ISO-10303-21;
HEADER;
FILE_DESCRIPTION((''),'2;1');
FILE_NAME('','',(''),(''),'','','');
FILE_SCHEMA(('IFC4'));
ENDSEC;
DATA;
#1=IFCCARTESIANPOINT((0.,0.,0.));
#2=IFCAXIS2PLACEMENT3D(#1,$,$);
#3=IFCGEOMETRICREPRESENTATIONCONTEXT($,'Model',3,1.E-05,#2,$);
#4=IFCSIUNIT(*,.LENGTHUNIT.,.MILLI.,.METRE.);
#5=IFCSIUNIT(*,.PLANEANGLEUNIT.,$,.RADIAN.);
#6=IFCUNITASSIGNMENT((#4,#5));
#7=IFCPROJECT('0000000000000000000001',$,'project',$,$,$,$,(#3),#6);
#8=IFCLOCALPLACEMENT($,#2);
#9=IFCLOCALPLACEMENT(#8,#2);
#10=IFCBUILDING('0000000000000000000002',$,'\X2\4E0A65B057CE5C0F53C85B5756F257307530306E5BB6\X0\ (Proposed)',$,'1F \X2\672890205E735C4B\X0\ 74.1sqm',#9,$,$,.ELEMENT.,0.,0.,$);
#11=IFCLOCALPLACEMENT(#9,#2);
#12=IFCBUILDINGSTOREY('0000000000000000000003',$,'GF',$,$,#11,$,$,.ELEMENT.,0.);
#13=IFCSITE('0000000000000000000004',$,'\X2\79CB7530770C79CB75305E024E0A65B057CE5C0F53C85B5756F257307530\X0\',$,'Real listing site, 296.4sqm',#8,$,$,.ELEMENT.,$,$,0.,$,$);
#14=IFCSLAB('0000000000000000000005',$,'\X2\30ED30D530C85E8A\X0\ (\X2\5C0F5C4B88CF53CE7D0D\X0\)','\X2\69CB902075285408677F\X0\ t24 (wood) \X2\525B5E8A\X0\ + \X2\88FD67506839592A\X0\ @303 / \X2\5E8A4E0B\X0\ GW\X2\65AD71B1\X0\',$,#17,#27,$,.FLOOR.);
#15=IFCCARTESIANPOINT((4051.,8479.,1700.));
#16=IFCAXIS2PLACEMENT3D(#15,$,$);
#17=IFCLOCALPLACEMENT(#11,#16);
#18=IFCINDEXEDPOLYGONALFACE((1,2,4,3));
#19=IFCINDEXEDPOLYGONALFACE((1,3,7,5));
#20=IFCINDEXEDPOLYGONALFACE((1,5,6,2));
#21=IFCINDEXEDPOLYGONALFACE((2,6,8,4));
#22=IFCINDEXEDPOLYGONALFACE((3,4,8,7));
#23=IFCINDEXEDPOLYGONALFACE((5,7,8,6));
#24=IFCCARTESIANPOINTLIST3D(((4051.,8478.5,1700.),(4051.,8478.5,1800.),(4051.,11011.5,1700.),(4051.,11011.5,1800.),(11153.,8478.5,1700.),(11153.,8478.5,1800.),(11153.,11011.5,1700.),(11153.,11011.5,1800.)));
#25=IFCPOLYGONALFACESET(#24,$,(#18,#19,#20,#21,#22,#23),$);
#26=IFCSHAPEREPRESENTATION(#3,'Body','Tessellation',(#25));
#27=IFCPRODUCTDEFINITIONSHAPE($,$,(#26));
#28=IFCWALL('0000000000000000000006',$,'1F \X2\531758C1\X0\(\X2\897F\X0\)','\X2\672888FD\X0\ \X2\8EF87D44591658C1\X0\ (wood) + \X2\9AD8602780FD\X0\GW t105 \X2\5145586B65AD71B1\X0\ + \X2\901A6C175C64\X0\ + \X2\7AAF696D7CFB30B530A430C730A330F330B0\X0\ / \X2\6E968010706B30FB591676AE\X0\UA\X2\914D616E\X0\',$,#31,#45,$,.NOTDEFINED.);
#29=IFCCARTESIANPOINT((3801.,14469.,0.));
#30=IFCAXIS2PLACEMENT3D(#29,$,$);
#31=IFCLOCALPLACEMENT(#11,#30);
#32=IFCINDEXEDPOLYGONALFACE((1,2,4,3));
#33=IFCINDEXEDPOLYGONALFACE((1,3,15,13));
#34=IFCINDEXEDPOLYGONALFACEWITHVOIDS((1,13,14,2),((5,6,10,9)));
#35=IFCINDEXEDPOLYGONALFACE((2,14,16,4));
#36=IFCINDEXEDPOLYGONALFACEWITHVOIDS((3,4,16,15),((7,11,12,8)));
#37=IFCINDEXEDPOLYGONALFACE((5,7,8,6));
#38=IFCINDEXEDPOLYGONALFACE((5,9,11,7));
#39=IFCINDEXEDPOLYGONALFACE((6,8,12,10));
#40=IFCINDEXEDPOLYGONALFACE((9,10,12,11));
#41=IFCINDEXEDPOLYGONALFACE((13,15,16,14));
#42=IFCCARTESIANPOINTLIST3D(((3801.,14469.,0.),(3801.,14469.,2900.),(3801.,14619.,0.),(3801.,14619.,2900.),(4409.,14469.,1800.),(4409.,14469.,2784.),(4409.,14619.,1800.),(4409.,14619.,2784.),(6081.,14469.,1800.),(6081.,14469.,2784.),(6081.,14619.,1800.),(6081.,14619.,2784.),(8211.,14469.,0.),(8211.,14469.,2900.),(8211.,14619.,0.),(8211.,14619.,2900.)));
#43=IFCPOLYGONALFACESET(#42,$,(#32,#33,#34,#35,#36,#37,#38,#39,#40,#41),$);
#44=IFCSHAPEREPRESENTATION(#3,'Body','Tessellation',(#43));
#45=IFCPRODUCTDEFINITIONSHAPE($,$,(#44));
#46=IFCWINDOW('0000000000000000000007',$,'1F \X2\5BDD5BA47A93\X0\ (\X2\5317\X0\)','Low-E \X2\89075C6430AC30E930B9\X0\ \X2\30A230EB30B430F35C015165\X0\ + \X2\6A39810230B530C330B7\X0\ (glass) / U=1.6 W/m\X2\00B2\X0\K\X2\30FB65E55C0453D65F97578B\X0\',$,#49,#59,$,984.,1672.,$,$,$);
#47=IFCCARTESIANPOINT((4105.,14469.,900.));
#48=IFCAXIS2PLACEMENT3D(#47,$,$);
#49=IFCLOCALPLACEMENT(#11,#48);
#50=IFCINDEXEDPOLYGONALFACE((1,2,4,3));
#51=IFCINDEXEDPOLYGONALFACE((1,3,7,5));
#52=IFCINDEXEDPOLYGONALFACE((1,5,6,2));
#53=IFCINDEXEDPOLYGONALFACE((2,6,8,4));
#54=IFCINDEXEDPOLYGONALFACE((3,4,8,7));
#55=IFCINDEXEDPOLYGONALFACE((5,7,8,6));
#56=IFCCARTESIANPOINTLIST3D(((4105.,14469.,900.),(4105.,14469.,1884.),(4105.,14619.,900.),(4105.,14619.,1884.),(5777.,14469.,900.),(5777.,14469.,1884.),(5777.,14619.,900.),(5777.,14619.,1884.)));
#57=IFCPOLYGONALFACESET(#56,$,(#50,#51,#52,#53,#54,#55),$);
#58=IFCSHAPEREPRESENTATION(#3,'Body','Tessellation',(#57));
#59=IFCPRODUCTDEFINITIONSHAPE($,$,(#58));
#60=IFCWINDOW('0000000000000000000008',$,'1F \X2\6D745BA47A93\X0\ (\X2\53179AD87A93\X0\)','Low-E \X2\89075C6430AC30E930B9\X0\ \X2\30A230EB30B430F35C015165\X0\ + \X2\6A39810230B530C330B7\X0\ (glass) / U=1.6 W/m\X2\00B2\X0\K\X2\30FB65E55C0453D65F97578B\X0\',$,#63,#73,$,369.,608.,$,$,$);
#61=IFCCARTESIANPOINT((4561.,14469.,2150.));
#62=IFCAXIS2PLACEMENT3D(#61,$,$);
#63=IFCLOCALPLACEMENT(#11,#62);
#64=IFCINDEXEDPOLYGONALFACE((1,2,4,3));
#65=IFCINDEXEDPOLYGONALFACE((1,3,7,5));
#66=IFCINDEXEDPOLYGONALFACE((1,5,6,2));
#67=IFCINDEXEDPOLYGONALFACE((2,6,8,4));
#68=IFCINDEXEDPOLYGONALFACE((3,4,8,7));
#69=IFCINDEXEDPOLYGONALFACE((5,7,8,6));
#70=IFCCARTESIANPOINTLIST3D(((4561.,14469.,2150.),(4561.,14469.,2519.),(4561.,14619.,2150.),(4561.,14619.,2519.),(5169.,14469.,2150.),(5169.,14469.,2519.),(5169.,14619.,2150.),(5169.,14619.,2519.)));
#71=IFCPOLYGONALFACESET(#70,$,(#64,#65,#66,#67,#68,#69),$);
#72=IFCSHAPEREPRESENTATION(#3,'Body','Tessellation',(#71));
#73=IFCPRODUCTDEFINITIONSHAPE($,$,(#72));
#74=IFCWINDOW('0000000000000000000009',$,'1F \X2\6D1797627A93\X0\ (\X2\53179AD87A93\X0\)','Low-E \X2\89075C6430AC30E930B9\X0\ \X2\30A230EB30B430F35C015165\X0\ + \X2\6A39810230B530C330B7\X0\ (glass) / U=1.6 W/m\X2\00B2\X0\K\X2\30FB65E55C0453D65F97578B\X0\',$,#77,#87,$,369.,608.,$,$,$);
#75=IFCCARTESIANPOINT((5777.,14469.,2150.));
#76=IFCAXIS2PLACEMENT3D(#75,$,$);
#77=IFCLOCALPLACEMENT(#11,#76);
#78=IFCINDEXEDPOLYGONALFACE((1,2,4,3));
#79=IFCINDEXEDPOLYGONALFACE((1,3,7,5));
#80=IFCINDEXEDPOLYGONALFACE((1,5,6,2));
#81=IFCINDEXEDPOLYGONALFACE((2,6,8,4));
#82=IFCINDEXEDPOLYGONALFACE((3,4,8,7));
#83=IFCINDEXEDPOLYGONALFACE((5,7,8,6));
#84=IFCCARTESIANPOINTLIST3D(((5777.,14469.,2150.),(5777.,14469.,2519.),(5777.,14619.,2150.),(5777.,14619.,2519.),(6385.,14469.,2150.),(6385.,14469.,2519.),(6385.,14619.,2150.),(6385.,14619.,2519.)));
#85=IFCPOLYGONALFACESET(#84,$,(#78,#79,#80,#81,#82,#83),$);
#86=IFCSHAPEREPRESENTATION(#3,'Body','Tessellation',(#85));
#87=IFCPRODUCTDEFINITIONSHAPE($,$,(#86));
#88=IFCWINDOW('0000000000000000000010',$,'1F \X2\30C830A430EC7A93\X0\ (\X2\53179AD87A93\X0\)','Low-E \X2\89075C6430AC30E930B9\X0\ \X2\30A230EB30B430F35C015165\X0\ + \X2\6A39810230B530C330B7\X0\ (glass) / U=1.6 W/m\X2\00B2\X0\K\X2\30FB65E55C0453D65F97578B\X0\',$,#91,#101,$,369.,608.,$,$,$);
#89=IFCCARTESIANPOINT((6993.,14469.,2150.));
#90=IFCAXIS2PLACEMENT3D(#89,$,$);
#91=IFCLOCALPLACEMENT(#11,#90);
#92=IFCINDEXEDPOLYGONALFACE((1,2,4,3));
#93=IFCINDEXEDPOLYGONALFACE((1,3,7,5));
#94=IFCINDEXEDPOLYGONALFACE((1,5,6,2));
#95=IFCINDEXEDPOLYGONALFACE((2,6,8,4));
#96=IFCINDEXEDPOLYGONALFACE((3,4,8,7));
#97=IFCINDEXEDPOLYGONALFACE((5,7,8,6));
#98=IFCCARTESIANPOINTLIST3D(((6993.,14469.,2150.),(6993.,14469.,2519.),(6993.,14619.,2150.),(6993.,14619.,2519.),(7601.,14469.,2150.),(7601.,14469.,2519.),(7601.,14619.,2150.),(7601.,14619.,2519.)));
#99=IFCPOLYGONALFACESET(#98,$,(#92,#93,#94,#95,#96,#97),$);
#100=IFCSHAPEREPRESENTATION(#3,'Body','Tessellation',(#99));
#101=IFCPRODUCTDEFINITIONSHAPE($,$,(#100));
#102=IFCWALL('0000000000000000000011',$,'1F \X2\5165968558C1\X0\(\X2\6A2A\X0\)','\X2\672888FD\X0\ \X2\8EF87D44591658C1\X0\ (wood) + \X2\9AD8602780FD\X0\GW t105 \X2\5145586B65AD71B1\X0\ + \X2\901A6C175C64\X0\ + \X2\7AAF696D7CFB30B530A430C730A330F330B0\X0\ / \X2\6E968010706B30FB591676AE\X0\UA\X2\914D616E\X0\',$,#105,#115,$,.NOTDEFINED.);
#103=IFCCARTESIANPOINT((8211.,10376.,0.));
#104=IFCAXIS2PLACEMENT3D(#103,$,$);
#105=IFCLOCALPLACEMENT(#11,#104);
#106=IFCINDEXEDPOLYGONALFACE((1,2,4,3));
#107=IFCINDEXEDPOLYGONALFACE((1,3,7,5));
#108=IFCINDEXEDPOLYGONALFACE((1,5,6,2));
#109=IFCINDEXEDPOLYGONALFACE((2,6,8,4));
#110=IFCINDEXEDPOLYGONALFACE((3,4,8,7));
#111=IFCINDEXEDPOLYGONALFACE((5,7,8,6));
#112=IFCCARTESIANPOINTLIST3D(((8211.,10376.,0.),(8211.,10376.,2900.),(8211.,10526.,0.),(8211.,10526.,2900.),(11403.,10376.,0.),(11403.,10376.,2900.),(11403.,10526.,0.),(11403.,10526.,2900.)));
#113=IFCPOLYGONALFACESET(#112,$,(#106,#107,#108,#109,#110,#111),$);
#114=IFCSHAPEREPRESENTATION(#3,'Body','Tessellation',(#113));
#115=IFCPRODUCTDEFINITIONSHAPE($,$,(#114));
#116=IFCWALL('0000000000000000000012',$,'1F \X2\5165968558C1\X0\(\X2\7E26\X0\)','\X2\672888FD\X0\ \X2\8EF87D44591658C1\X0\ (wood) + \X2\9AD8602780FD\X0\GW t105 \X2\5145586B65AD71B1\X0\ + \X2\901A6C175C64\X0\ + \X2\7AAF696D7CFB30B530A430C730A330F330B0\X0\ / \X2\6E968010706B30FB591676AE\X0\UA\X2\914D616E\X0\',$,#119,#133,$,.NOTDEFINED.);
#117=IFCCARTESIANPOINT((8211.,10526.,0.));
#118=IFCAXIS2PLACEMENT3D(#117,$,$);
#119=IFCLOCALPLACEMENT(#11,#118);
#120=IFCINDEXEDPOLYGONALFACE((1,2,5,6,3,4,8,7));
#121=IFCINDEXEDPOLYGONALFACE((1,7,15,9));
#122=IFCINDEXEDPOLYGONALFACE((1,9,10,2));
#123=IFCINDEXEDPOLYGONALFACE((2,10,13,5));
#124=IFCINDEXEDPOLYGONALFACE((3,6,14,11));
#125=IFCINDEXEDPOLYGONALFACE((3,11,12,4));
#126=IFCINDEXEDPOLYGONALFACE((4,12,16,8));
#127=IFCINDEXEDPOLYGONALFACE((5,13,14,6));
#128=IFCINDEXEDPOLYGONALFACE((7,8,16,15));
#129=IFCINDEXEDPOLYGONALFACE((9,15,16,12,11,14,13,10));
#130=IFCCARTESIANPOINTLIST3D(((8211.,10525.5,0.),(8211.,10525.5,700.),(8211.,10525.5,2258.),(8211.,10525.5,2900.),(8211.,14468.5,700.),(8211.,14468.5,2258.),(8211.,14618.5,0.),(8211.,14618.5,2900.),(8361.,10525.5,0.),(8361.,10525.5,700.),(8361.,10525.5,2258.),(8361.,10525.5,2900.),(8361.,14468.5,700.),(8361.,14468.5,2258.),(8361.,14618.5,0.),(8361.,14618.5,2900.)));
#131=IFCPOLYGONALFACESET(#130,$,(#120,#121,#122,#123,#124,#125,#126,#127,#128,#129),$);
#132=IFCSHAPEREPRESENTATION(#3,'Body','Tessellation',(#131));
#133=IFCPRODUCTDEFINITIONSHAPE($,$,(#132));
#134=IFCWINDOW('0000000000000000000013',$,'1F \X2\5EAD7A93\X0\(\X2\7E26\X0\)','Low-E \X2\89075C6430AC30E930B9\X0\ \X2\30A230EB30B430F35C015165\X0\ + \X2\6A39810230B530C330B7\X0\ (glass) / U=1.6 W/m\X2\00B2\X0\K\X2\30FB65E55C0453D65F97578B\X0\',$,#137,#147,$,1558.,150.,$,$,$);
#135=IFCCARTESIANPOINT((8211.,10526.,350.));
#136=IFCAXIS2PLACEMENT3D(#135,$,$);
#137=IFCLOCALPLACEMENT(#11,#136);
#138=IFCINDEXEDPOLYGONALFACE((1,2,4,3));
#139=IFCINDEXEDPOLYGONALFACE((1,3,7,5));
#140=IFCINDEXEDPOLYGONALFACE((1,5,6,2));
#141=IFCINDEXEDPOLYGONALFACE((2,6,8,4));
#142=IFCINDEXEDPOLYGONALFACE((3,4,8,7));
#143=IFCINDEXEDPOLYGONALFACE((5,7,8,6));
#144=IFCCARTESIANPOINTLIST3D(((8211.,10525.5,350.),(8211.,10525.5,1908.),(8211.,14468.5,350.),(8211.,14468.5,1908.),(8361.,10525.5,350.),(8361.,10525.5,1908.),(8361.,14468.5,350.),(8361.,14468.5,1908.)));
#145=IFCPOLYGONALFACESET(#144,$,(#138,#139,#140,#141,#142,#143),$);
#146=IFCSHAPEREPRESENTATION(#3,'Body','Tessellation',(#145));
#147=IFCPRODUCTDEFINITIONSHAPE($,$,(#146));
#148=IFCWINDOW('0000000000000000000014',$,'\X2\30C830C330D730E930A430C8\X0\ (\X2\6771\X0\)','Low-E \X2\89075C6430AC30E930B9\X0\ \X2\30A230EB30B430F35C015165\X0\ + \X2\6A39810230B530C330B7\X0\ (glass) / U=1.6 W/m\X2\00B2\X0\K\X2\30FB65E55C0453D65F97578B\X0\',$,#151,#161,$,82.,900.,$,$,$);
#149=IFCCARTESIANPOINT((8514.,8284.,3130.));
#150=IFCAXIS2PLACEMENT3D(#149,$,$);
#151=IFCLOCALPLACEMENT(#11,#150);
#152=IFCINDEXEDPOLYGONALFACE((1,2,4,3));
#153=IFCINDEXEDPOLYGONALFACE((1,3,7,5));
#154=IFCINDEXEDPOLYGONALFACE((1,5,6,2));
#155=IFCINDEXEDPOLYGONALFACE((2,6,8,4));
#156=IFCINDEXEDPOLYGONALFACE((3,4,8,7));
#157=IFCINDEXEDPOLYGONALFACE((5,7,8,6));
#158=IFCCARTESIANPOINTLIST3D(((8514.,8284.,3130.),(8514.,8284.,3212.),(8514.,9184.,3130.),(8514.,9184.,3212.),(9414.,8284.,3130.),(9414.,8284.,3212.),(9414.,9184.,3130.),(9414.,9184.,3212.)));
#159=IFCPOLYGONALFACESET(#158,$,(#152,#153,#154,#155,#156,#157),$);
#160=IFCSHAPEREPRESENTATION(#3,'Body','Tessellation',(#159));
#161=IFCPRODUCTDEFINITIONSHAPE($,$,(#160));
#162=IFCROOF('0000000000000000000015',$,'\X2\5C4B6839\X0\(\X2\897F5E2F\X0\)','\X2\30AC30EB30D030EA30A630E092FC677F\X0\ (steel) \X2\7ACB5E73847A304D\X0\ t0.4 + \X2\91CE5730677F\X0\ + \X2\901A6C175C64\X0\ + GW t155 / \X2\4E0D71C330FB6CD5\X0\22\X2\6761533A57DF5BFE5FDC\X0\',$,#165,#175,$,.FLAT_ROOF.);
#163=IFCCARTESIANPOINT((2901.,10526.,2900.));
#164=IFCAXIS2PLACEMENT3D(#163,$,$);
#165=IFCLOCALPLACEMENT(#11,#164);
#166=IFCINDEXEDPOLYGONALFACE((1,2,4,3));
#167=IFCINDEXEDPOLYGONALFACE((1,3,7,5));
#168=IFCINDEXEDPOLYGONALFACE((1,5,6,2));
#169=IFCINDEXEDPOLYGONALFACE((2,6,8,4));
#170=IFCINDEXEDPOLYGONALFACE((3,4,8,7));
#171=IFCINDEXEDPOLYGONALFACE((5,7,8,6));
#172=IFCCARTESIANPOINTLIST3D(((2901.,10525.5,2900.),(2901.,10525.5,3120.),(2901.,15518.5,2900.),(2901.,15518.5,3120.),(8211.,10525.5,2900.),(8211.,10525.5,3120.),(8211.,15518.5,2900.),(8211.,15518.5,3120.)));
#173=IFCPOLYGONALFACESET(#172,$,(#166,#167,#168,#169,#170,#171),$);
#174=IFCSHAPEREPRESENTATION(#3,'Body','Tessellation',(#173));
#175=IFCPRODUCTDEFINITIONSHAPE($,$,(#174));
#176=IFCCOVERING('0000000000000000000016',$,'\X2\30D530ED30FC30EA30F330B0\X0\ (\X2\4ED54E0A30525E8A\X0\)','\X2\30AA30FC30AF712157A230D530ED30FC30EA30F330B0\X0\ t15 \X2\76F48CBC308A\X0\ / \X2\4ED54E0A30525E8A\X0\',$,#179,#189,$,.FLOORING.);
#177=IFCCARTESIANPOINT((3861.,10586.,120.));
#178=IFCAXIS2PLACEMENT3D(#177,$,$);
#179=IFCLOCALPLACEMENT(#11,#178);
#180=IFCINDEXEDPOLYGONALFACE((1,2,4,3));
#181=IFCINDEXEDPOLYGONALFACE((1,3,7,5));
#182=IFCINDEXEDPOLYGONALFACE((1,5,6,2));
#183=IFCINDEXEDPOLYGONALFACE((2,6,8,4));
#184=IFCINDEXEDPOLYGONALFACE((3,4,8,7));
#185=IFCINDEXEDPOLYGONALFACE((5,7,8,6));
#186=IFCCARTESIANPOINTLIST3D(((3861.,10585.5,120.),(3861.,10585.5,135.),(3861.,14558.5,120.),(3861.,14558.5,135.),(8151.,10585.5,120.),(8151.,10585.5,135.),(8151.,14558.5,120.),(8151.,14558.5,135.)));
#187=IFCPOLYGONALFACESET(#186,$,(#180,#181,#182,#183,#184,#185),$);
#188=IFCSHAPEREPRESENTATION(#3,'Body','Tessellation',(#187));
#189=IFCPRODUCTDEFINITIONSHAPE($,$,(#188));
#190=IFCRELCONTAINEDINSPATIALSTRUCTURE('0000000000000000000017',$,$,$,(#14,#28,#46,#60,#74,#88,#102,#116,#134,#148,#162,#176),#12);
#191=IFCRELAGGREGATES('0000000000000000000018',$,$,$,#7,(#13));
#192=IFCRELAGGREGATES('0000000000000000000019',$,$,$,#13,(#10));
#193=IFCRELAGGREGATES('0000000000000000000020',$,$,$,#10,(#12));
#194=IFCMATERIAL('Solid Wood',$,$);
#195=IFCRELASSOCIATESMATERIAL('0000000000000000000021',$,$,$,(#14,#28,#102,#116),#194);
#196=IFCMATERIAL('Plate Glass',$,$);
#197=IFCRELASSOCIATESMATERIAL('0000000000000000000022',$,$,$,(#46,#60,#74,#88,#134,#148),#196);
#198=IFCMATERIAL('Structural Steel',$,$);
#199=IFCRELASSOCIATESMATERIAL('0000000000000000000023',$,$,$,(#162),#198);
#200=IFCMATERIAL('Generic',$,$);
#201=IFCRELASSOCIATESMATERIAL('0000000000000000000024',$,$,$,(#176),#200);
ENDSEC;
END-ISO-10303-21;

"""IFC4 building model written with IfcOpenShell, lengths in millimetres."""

from ifc_helpers import new_model, si_unit, frame, frame_2d, origin, place, context, project, spatial, rectangle, extrude, material, element, fill, save


model = new_model("IFC4")

# Units and contexts
model_context = context("Model", 3, precision=1e-05, world=origin())
ifc_project = project(units=[si_unit("LENGTHUNIT", "METRE", prefix="MILLI"), si_unit("PLANEANGLEUNIT", "RADIAN")], contexts=[model_context])

# Site, building, storey
site_placement = place(None, origin())
site = spatial("IfcSite", under=ifc_project, at=site_placement, Name="秋田県秋田市上新城小又字囲地田", ObjectType="Real listing site, 296.4sqm", CompositionType="ELEMENT", RefElevation=0.0)
building_placement = place(site_placement, origin())
building = spatial("IfcBuilding", under=site, at=building_placement, Name="上新城小又字囲地田の家 (Proposed)", ObjectType="1F 木造平屋 74.1sqm", CompositionType="ELEMENT", ElevationOfRefHeight=0.0, ElevationOfTerrain=0.0)
storey_placement = place(building_placement, origin())
storey = spatial("IfcBuildingStorey", under=building, at=storey_placement, Name="GF", CompositionType="ELEMENT", Elevation=0.0)

# Slab
ifc_material_1 = material(Name="Solid Wood")
slab_1_placement = place(storey_placement, frame((4051.0, 8479.0, 1700.0)))
element("IfcSlab", 1, at=slab_1_placement, inside=storey, material=ifc_material_1, Name="ロフト床 (小屋裏収納)", Description="構造用合板 t24 (wood) 剛床 + 製材根太 @303 / 床下 GW断熱", PredefinedType="FLOOR", context=model_context, shape_type="SweptSolid", body=[
    extrude(rectangle(XDim=7102.0, YDim=2533.0, at=frame_2d((3551.0, 1266.0))), frame((4051.0, 8479.0, 1700.0)), (0.0, 0.0, 1.0), 100.0),
])

# Wall, openings, windows
wall_1_placement = place(storey_placement, frame((3801.0, 14469.0, 0.0)))
wall_1 = element("IfcWall", 2, at=wall_1_placement, inside=storey, material=ifc_material_1, Name="1F 北壁(西)", Description="木製 軸組外壁 (wood) + 高性能GW t105 充填断熱 + 通気層 + 窯業系サイディング / 準耐火・外皮UA配慮", PredefinedType="NOTDEFINED", context=model_context, shape_type="SweptSolid", body=[
    extrude(rectangle(XDim=4410.0, YDim=150.0, at=frame_2d((2205.0, 75.0))), frame((3801.0, 14469.0, 0.0)), (0.0, 0.0, 1.0), 2900.0),
])
opening_1_placement = place(storey_placement, frame((4105.0, 14469.0, 900.0)))
opening_1 = element("IfcOpeningElement", 3, at=opening_1_placement, cuts=wall_1, PredefinedType="NOTDEFINED", context=model_context, shape_type="SweptSolid", body=[
    extrude(rectangle(XDim=1672.0, YDim=150.0, at=frame_2d((836.0, 75.0))), frame((4105.0, 14469.0, 900.0)), (0.0, 0.0, 1.0), 984.0),
])
opening_2_placement = place(storey_placement, frame((4561.0, 14469.0, 2150.0)))
opening_2 = element("IfcOpeningElement", 4, at=opening_2_placement, cuts=wall_1, PredefinedType="NOTDEFINED", context=model_context, shape_type="SweptSolid", body=[
    extrude(rectangle(XDim=608.0, YDim=150.0, at=frame_2d((304.0, 75.0))), frame((4561.0, 14469.0, 2150.0)), (0.0, 0.0, 1.0), 369.0),
])
opening_3_placement = place(storey_placement, frame((5777.0, 14469.0, 2150.0)))
opening_3 = element("IfcOpeningElement", 5, at=opening_3_placement, cuts=wall_1, PredefinedType="NOTDEFINED", context=model_context, shape_type="SweptSolid", body=[
    extrude(rectangle(XDim=608.0, YDim=150.0, at=frame_2d((304.0, 75.0))), frame((5777.0, 14469.0, 2150.0)), (0.0, 0.0, 1.0), 369.0),
])
opening_4_placement = place(storey_placement, frame((6993.0, 14469.0, 2150.0)))
opening_4 = element("IfcOpeningElement", 6, at=opening_4_placement, cuts=wall_1, PredefinedType="NOTDEFINED", context=model_context, shape_type="SweptSolid", body=[
    extrude(rectangle(XDim=608.0, YDim=150.0, at=frame_2d((304.0, 75.0))), frame((6993.0, 14469.0, 2150.0)), (0.0, 0.0, 1.0), 369.0),
])
ifc_material_2 = material(Name="Plate Glass")
window_1_placement = place(storey_placement, frame((4105.0, 14469.0, 900.0)))
window_1 = element("IfcWindow", 7, at=window_1_placement, inside=storey, material=ifc_material_2, Name="1F 寝室窓 (北)", Description="Low-E 複層ガラス アルゴン封入 + 樹脂サッシ (glass) / U=1.6 W/m²K・日射取得型", OverallHeight=984.0, OverallWidth=1672.0, context=model_context, shape_type="SweptSolid", body=[
    extrude(rectangle(XDim=1672.0, YDim=150.0, at=frame_2d((836.0, 75.0))), frame((4105.0, 14469.0, 900.0)), (0.0, 0.0, 1.0), 984.0),
])
fill(opening_1, window_1)
window_2_placement = place(storey_placement, frame((4561.0, 14469.0, 2150.0)))
window_2 = element("IfcWindow", 8, at=window_2_placement, inside=storey, material=ifc_material_2, Name="1F 浴室窓 (北高窓)", Description="Low-E 複層ガラス アルゴン封入 + 樹脂サッシ (glass) / U=1.6 W/m²K・日射取得型", OverallHeight=369.0, OverallWidth=608.0, context=model_context, shape_type="SweptSolid", body=[
    extrude(rectangle(XDim=608.0, YDim=150.0, at=frame_2d((304.0, 75.0))), frame((4561.0, 14469.0, 2150.0)), (0.0, 0.0, 1.0), 369.0),
])
fill(opening_2, window_2)
window_3_placement = place(storey_placement, frame((5777.0, 14469.0, 2150.0)))
window_3 = element("IfcWindow", 9, at=window_3_placement, inside=storey, material=ifc_material_2, Name="1F 洗面窓 (北高窓)", Description="Low-E 複層ガラス アルゴン封入 + 樹脂サッシ (glass) / U=1.6 W/m²K・日射取得型", OverallHeight=369.0, OverallWidth=608.0, context=model_context, shape_type="SweptSolid", body=[
    extrude(rectangle(XDim=608.0, YDim=150.0, at=frame_2d((304.0, 75.0))), frame((5777.0, 14469.0, 2150.0)), (0.0, 0.0, 1.0), 369.0),
])
fill(opening_3, window_3)
window_4_placement = place(storey_placement, frame((6993.0, 14469.0, 2150.0)))
window_4 = element("IfcWindow", 10, at=window_4_placement, inside=storey, material=ifc_material_2, Name="1F トイレ窓 (北高窓)", Description="Low-E 複層ガラス アルゴン封入 + 樹脂サッシ (glass) / U=1.6 W/m²K・日射取得型", OverallHeight=369.0, OverallWidth=608.0, context=model_context, shape_type="SweptSolid", body=[
    extrude(rectangle(XDim=608.0, YDim=150.0, at=frame_2d((304.0, 75.0))), frame((6993.0, 14469.0, 2150.0)), (0.0, 0.0, 1.0), 369.0),
])
fill(opening_4, window_4)

# Wall
wall_2_placement = place(storey_placement, frame((8211.0, 10376.0, 0.0)))
element("IfcWall", 11, at=wall_2_placement, inside=storey, material=ifc_material_1, Name="1F 入隅壁(横)", Description="木製 軸組外壁 (wood) + 高性能GW t105 充填断熱 + 通気層 + 窯業系サイディング / 準耐火・外皮UA配慮", PredefinedType="NOTDEFINED", context=model_context, shape_type="SweptSolid", body=[
    extrude(rectangle(XDim=3192.0, YDim=150.0, at=frame_2d((1596.0, 75.0))), frame((8211.0, 10376.0, 0.0)), (0.0, 0.0, 1.0), 2900.0),
])

# Wall, opening, window
wall_3_placement = place(storey_placement, frame((8211.0, 10526.0, 0.0)))
wall_3 = element("IfcWall", 12, at=wall_3_placement, inside=storey, material=ifc_material_1, Name="1F 入隅壁(縦)", Description="木製 軸組外壁 (wood) + 高性能GW t105 充填断熱 + 通気層 + 窯業系サイディング / 準耐火・外皮UA配慮", PredefinedType="NOTDEFINED", context=model_context, shape_type="SweptSolid", body=[
    extrude(rectangle(XDim=150.0, YDim=4093.0, at=frame_2d((75.0, 2046.0))), frame((8211.0, 10526.0, 0.0)), (0.0, 0.0, 1.0), 2900.0),
])
opening_5_placement = place(storey_placement, frame((8211.0, 10526.0, 350.0)))
opening_5 = element("IfcOpeningElement", 13, at=opening_5_placement, cuts=wall_3, PredefinedType="NOTDEFINED", context=model_context, shape_type="SweptSolid", body=[
    extrude(rectangle(XDim=150.0, YDim=3943.0, at=frame_2d((75.0, 1971.0))), frame((8211.0, 10526.0, 350.0)), (0.0, 0.0, 1.0), 1558.0),
])
window_5_placement = place(storey_placement, frame((8211.0, 10526.0, 350.0)))
window_5 = element("IfcWindow", 14, at=window_5_placement, inside=storey, material=ifc_material_2, Name="1F 庭窓(縦)", Description="Low-E 複層ガラス アルゴン封入 + 樹脂サッシ (glass) / U=1.6 W/m²K・日射取得型", OverallHeight=1558.0, OverallWidth=150.0, context=model_context, shape_type="SweptSolid", body=[
    extrude(rectangle(XDim=150.0, YDim=3943.0, at=frame_2d((75.0, 1971.0))), frame((8211.0, 10526.0, 350.0)), (0.0, 0.0, 1.0), 1558.0),
])
fill(opening_5, window_5)

# Window
window_6_placement = place(storey_placement, frame((8514.0, 8284.0, 3130.0)))
element("IfcWindow", 15, at=window_6_placement, inside=storey, material=ifc_material_2, Name="トップライト (東)", Description="Low-E 複層ガラス アルゴン封入 + 樹脂サッシ (glass) / U=1.6 W/m²K・日射取得型", OverallHeight=82.0, OverallWidth=900.0, context=model_context, shape_type="SweptSolid", body=[
    extrude(rectangle(XDim=900.0, YDim=900.0, at=frame_2d((450.0, 450.0))), frame((8514.0, 8284.0, 3130.0)), (0.0, 0.0, 1.0), 82.0),
])

# Roof
ifc_material_3 = material(Name="Structural Steel")
roof_placement = place(storey_placement, frame((2901.0, 10526.0, 2900.0)))
element("IfcRoof", 16, at=roof_placement, inside=storey, material=ifc_material_3, Name="屋根(西帯)", Description="ガルバリウム鋼板 (steel) 立平葺き t0.4 + 野地板 + 通気層 + GW t155 / 不燃・法22条区域対応", PredefinedType="FLAT_ROOF", context=model_context, shape_type="SweptSolid", body=[
    extrude(rectangle(XDim=5310.0, YDim=4993.0, at=frame_2d((2655.0, 2496.0))), frame((2901.0, 10526.0, 2900.0)), (0.0, 0.0, 1.0), 220.0),
])

# Covering
ifc_material_4 = material(Name="Generic")
covering_placement = place(storey_placement, frame((3861.0, 10586.0, 120.0)))
element("IfcCovering", 17, at=covering_placement, inside=storey, material=ifc_material_4, Name="フローリング (仕上げ床)", Description="オーク無垢フローリング t15 直貼り / 仕上げ床", PredefinedType="FLOORING", context=model_context, shape_type="SweptSolid", body=[
    extrude(rectangle(XDim=4290.0, YDim=3973.0, at=frame_2d((2145.0, 1986.0))), frame((3861.0, 10586.0, 120.0)), (0.0, 0.0, 1.0), 15.0),
])

save(model, "model.ifc")
